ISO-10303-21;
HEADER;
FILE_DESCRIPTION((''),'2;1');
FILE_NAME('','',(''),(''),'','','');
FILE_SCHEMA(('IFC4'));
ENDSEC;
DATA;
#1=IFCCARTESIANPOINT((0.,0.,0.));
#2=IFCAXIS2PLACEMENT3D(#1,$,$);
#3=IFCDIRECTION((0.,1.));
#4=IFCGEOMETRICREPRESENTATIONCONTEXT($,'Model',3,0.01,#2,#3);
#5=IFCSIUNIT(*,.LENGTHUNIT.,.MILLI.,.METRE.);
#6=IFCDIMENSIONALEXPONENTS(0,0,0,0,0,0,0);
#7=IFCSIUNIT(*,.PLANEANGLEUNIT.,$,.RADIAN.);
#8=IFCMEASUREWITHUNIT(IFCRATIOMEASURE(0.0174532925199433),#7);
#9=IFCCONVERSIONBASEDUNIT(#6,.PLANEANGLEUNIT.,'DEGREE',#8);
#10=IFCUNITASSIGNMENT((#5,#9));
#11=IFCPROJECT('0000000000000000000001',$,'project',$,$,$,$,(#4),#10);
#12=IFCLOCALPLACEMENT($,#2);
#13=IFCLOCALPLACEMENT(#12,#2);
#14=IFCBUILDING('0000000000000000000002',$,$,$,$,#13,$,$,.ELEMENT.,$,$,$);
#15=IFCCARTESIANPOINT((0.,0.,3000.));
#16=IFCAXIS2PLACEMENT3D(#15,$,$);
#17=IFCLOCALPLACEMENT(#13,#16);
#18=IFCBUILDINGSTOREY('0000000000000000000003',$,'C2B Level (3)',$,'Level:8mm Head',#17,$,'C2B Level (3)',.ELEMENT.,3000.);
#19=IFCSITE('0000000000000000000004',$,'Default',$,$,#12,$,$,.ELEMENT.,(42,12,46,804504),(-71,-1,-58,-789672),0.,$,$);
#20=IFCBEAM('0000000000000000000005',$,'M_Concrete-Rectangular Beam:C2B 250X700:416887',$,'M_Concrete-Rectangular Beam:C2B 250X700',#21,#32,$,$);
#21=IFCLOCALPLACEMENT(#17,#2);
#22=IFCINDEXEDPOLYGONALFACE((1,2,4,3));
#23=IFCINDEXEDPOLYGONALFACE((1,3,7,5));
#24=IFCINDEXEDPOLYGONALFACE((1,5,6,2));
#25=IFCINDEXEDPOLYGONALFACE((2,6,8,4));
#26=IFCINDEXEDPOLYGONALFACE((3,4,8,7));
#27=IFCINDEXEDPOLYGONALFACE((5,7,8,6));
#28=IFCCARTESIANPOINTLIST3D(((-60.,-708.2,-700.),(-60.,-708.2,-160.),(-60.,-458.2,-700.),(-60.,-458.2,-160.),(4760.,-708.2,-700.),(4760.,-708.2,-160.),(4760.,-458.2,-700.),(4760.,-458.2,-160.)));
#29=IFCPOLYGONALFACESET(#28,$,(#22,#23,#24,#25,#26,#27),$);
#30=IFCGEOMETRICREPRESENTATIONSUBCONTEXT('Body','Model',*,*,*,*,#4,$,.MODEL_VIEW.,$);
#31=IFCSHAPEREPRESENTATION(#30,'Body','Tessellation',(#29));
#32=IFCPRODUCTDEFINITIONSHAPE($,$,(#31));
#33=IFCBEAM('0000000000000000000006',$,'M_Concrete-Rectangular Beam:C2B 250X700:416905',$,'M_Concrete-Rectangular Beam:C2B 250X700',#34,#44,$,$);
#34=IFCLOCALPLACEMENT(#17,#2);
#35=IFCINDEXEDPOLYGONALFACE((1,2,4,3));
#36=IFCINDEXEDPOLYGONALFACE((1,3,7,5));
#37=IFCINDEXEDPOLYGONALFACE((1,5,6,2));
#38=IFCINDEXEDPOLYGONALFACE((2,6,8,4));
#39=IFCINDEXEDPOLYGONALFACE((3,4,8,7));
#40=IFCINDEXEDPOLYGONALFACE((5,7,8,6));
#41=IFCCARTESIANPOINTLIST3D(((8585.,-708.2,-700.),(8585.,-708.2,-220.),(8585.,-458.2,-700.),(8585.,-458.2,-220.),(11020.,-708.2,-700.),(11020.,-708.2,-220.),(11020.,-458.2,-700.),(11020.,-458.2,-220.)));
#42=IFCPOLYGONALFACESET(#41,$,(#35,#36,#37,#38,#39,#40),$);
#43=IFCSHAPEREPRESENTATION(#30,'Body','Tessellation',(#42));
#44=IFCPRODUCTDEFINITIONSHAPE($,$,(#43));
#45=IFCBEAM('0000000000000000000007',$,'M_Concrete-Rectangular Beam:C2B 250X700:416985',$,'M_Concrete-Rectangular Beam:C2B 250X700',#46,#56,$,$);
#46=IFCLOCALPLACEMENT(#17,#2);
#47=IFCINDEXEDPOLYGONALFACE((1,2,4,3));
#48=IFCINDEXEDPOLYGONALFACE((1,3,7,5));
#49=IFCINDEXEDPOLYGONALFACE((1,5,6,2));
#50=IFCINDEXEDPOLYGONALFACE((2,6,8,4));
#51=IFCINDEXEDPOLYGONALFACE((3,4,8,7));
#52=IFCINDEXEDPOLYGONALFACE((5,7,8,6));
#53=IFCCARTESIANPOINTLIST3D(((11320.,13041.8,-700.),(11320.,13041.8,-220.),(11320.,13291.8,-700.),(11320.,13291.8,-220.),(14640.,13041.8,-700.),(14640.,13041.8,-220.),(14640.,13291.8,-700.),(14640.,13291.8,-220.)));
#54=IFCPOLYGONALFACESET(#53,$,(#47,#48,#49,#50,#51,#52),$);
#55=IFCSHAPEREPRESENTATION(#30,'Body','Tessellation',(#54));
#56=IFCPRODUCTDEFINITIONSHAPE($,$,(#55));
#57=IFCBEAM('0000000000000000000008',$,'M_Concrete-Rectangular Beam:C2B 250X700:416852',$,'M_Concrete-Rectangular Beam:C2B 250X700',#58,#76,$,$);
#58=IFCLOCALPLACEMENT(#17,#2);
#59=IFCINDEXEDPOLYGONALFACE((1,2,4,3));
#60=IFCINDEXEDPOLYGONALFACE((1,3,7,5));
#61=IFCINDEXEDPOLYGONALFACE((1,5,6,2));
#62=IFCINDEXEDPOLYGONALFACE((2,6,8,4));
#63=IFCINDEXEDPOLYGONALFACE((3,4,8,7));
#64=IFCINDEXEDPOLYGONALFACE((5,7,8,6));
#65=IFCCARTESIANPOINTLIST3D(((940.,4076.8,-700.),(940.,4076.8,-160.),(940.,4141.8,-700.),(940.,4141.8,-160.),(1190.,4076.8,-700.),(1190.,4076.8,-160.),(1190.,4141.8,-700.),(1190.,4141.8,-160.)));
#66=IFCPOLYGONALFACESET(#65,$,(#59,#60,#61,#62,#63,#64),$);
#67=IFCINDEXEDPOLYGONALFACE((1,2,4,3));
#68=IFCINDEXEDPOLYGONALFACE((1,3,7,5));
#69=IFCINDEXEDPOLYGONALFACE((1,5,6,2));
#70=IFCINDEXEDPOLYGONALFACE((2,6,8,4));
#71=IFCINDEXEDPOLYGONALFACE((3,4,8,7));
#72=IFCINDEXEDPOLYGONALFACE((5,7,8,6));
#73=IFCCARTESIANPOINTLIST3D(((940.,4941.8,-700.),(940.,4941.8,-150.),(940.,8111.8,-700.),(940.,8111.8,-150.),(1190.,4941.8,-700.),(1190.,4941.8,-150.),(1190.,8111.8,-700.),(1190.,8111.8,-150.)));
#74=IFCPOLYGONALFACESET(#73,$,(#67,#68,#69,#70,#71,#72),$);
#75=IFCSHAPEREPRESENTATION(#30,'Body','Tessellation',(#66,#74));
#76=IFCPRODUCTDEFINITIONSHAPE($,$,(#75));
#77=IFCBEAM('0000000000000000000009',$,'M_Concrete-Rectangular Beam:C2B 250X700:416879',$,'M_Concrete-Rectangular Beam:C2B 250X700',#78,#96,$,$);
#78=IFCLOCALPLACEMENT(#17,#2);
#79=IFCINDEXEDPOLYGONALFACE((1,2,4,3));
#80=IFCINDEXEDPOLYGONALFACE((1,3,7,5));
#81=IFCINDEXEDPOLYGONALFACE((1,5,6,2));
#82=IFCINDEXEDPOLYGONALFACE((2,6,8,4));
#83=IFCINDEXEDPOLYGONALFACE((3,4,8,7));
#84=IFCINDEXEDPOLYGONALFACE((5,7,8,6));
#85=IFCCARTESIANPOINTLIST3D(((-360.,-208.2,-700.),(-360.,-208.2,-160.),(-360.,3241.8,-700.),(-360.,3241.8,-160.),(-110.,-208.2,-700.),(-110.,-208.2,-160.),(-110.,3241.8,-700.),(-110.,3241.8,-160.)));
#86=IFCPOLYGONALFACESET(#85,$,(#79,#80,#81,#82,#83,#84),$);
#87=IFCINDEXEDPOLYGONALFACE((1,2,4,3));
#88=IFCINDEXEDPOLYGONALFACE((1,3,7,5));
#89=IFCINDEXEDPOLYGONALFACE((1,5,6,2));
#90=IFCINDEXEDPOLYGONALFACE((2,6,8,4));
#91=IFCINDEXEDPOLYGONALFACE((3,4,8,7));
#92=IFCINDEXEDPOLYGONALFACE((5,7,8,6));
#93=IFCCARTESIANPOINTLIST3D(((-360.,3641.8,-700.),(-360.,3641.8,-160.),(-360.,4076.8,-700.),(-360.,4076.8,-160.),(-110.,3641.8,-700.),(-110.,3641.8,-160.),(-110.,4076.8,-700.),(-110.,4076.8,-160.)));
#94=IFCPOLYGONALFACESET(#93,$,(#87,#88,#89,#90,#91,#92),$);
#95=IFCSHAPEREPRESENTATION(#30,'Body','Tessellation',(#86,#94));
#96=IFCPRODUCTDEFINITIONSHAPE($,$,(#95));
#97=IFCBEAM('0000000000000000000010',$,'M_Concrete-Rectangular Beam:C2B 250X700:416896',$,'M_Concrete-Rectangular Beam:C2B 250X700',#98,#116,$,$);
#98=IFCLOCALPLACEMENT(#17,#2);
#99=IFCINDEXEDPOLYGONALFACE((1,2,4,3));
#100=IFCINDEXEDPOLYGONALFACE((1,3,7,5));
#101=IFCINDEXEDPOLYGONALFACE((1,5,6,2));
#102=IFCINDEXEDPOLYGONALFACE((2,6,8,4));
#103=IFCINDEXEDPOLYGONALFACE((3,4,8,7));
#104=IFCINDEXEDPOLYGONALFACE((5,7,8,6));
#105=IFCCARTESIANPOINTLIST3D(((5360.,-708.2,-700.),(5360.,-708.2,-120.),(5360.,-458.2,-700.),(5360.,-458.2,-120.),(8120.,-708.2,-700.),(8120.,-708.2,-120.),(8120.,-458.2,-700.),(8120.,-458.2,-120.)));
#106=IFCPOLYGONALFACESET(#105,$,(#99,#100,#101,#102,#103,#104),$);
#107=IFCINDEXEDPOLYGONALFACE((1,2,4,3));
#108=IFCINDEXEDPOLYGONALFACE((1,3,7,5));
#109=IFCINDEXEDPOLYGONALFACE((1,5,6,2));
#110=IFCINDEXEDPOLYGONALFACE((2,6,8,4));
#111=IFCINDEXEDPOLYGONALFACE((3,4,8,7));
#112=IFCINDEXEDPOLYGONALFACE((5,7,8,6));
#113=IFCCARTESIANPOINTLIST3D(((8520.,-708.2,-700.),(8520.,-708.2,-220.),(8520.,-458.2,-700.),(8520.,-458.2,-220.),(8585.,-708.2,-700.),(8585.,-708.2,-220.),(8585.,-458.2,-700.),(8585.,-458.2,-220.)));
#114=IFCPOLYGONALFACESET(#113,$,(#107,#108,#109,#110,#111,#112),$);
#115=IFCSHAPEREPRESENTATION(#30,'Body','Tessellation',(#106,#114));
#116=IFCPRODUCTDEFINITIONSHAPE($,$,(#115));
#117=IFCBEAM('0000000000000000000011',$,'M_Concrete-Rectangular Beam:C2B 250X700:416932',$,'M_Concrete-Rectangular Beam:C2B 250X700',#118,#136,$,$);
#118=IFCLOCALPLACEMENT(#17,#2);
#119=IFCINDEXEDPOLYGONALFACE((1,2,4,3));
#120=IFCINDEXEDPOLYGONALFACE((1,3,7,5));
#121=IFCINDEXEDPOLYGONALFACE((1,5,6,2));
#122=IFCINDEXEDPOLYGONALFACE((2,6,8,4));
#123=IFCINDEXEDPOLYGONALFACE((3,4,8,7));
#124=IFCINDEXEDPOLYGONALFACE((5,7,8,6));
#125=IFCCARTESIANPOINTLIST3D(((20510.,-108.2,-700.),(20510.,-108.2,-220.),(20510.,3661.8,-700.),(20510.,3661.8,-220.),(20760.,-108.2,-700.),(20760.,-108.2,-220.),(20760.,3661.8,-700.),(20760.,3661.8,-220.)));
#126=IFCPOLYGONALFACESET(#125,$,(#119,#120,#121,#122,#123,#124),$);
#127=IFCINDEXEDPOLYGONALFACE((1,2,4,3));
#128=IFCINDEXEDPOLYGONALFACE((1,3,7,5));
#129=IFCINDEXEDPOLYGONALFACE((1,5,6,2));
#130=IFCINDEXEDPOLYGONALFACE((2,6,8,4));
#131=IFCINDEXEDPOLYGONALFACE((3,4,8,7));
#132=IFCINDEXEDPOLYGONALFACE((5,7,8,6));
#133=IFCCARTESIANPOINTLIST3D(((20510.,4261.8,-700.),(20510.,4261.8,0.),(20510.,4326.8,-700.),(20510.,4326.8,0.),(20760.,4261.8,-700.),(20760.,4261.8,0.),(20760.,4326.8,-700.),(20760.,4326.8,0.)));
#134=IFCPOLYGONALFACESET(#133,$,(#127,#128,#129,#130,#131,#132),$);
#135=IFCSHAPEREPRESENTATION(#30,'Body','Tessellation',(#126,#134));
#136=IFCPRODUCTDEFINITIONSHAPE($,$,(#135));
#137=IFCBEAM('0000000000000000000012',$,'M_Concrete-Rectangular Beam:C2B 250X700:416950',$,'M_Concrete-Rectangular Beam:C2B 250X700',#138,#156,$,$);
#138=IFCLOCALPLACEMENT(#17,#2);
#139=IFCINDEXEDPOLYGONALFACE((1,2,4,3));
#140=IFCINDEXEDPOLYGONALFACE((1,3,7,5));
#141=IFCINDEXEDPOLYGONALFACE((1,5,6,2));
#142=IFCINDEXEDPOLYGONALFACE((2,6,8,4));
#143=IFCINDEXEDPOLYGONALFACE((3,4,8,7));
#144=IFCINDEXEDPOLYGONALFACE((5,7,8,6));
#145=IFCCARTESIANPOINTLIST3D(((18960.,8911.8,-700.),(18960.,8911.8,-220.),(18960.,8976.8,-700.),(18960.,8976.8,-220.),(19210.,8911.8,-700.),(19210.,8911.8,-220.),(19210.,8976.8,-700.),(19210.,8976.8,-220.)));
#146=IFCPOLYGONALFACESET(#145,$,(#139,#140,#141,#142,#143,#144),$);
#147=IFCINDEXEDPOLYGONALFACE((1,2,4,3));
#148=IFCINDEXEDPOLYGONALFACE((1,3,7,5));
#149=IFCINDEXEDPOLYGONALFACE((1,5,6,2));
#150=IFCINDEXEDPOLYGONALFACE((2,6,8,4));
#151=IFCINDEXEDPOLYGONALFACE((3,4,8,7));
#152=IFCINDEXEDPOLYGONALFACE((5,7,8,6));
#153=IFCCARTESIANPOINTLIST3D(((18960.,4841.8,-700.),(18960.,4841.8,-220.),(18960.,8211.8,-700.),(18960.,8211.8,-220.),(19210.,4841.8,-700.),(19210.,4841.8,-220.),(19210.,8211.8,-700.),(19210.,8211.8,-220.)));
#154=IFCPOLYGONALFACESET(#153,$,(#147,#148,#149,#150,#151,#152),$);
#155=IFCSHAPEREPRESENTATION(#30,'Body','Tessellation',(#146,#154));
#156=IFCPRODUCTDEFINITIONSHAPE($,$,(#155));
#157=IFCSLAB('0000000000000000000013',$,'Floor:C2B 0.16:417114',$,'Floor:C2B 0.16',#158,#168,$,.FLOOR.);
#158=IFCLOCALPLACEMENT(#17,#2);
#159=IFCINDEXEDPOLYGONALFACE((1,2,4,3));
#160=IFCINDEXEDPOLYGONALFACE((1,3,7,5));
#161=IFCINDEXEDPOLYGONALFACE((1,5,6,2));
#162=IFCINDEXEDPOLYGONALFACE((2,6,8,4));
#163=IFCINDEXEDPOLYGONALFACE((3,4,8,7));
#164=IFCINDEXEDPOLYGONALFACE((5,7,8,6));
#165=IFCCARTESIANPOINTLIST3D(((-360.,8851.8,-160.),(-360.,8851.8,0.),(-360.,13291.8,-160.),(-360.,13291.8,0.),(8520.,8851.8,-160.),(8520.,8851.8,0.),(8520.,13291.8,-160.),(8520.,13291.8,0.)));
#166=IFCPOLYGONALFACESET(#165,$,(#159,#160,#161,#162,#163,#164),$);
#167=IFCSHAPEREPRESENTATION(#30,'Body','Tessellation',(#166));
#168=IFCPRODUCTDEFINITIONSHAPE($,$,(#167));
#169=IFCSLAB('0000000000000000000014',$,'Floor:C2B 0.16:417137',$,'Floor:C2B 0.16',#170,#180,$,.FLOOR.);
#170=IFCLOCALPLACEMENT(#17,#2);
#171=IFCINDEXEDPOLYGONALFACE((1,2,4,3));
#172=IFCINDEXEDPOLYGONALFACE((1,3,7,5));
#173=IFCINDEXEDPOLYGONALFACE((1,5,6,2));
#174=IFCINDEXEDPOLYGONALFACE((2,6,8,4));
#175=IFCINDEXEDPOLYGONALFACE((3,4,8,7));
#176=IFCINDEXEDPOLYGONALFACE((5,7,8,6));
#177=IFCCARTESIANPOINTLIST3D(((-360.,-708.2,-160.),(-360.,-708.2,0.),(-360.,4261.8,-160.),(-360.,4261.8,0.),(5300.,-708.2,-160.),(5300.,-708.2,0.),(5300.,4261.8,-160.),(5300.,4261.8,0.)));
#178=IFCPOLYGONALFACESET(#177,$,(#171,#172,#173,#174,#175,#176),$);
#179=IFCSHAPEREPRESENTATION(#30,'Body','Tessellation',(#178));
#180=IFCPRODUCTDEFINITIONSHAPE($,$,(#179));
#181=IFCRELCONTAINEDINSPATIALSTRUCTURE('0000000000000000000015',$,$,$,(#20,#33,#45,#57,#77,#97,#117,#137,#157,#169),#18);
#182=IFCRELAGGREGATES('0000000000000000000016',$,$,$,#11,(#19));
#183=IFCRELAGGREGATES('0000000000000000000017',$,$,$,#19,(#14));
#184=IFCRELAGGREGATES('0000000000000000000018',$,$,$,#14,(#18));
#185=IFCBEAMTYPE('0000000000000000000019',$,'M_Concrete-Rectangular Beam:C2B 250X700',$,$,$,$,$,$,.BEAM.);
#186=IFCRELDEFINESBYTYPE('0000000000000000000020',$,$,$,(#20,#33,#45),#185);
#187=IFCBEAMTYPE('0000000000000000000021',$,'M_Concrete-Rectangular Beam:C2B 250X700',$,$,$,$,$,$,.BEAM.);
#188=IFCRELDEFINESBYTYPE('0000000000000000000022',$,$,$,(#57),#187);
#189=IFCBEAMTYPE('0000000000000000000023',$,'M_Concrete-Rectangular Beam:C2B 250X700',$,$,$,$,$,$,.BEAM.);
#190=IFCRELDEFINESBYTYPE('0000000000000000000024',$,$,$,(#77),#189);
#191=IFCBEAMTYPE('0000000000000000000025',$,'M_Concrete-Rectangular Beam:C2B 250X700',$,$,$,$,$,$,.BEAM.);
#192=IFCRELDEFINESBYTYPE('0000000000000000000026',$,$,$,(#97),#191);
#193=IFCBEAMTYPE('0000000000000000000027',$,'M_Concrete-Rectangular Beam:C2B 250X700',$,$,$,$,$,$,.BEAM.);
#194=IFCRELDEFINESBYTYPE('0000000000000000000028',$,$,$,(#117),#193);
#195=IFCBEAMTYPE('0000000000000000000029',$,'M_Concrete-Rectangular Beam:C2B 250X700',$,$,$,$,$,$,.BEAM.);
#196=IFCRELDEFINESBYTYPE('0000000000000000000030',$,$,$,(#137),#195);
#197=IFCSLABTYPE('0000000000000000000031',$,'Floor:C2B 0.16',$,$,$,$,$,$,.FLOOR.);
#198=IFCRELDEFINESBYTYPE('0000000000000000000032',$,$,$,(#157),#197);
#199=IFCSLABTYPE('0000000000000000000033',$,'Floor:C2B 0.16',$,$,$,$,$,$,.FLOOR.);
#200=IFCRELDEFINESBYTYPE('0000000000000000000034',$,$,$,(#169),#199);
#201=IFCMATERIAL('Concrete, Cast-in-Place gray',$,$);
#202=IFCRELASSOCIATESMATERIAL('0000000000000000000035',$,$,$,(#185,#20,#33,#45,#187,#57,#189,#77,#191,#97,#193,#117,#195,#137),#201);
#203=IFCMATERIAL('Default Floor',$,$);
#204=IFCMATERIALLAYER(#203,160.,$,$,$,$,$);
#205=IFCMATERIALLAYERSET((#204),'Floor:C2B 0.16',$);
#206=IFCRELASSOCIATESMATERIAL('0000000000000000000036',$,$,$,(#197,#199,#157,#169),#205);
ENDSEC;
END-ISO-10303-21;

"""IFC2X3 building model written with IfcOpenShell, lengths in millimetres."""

from ifc_helpers import new_model, entity, si_unit, converted_unit, direction, frame, frame_2d, origin, place, context, subcontext, project, spatial, rectangle, extrude, source, transform, mapped, material, layer, layer_set, layer_usage, type_object, type_shapes, element, save


model = new_model("IFC2X3")

# Units and contexts
model_context = context("Model", 3, precision=0.01, world=origin(), true_north=direction((0.0, 1.0)))
body_context = subcontext(model_context, "Body", "Model", "MODEL_VIEW")
ifc_project = project(units=[si_unit("LENGTHUNIT", "METRE", prefix="MILLI"), converted_unit("PLANEANGLEUNIT", "DEGREE", entity("IfcRatioMeasure", 0.0174532925199433), si_unit("PLANEANGLEUNIT", "RADIAN"), dimensions=[0, 0, 0, 0, 0, 0, 0])], contexts=[model_context])

# Site, building, storey
site_placement = place(None, origin())
site = spatial("IfcSite", under=ifc_project, at=site_placement, Name="Default", CompositionType="ELEMENT", RefLatitude=(42, 12, 46, 804504), RefLongitude=(-71, -1, -58, -789672), RefElevation=0.0)
building_placement = place(site_placement, origin())
building = spatial("IfcBuilding", under=site, at=building_placement, CompositionType="ELEMENT")
storey_placement = place(building_placement, frame((0.0, 0.0, 3000.0)))
storey = spatial("IfcBuildingStorey", under=building, at=storey_placement, Name="C2B Level (3)", ObjectType="Level:8mm Head", LongName="C2B Level (3)", CompositionType="ELEMENT", Elevation=3000.0)

# Beams
ifc_material_1 = material(Name="Concrete, Cast-in-Place gray")
beam_type_1 = type_object("IfcBeamType", Name="M_Concrete-Rectangular Beam:C2B 250X700", PredefinedType="BEAM", material=ifc_material_1)
beam_1_placement = place(storey_placement, frame((4760.0, -583.2, 0.0), z_axis=(0.0, 0.0, 1.0), x_axis=(-1.0, 0.0, 0.0)))
element("IfcBeam", 1, at=beam_1_placement, inside=storey, type_object=beam_type_1, material=ifc_material_1, Name="M_Concrete-Rectangular Beam:C2B 250X700:416887", ObjectType="M_Concrete-Rectangular Beam:C2B 250X700", context=body_context, shape_type="SweptSolid", body=[
    extrude(rectangle(XDim=540.0, YDim=250.0, at=frame_2d((0.0, 0.0), x_axis=(1.0, 0.0))), frame((0.0, 0.0, -430.0), z_axis=(1.0, 0.0, 0.0), x_axis=(0.0, 0.0, -1.0)), (0.0, 0.0, 1.0), 4820.0),
])
beam_2_placement = place(storey_placement, frame((8460.0, -583.2, 0.0)))
element("IfcBeam", 2, at=beam_2_placement, inside=storey, type_object=beam_type_1, material=ifc_material_1, Name="M_Concrete-Rectangular Beam:C2B 250X700:416905", ObjectType="M_Concrete-Rectangular Beam:C2B 250X700", context=body_context, shape_type="SweptSolid", body=[
    extrude(rectangle(XDim=480.0, YDim=250.0, at=frame_2d((0.0, 0.0), x_axis=(1.0, 0.0))), frame((125.0, 0.0, -460.0), z_axis=(1.0, 0.0, 0.0), x_axis=(0.0, 0.0, -1.0)), (0.0, 0.0, 1.0), 2435.0),
])
beam_3_placement = place(storey_placement, frame((14640.0, 13166.8, 0.0), z_axis=(0.0, 0.0, 1.0), x_axis=(-1.0, 0.0, 0.0)))
element("IfcBeam", 3, at=beam_3_placement, inside=storey, type_object=beam_type_1, material=ifc_material_1, Name="M_Concrete-Rectangular Beam:C2B 250X700:416985", ObjectType="M_Concrete-Rectangular Beam:C2B 250X700", context=body_context, shape_type="SweptSolid", body=[
    extrude(rectangle(XDim=480.0, YDim=250.0, at=frame_2d((0.0, 0.0), x_axis=(1.0, 0.0))), frame((0.0, 0.0, -460.0), z_axis=(1.0, 0.0, 0.0), x_axis=(0.0, 0.0, -1.0)), (0.0, 0.0, 1.0), 3320.0),
])
beam_type_2 = type_object("IfcBeamType", Name="M_Concrete-Rectangular Beam:C2B 250X700", PredefinedType="BEAM", material=ifc_material_1)
shared_shape_1 = source(origin(), body_context, "Body", "SweptSolid", [
    extrude(rectangle(XDim=540.0, YDim=250.0, at=frame_2d((0.0, 0.0), x_axis=(0.0, 1.0))), frame((1065.0, 4141.8, 2570.0), z_axis=(0.0, -1.0, 0.0), x_axis=(-1.0, 0.0, 0.0)), (0.0, 0.0, 1.0), 65.0),
    extrude(rectangle(XDim=550.0, YDim=250.0, at=frame_2d((0.0, 0.0), x_axis=(0.0, 1.0))), frame((1065.0, 8111.8, 2575.0), z_axis=(0.0, -1.0, 0.0), x_axis=(-1.0, 0.0, 0.0)), (0.0, 0.0, 1.0), 3170.0),
])
type_shapes(beam_type_2, [shared_shape_1])
beam_4_placement = place(storey_placement, frame((0.0, 0.0, -3000.0)))
element("IfcBeam", 4, at=beam_4_placement, inside=storey, type_object=beam_type_2, material=ifc_material_1, Name="M_Concrete-Rectangular Beam:C2B 250X700:416852", ObjectType="M_Concrete-Rectangular Beam:C2B 250X700", context=body_context, shape_type="MappedRepresentation", body=[
    mapped(shared_shape_1, transform((0.0, 0.0, 0.0), scale=1.0)),
])
beam_type_3 = type_object("IfcBeamType", Name="M_Concrete-Rectangular Beam:C2B 250X700", PredefinedType="BEAM", material=ifc_material_1)
shared_shape_2 = source(origin(), body_context, "Body", "SweptSolid", [
    extrude(rectangle(XDim=540.0, YDim=250.0, at=frame_2d((0.0, 0.0), x_axis=(0.0, 1.0))), frame((-235.0, 3241.8, 2570.0), z_axis=(0.0, -1.0, 0.0), x_axis=(-1.0, 0.0, 0.0)), (0.0, 0.0, 1.0), 3450.0),
    extrude(rectangle(XDim=540.0, YDim=250.0, at=frame_2d((0.0, 0.0), x_axis=(0.0, 1.0))), frame((-235.0, 4076.8, 2570.0), z_axis=(0.0, -1.0, 0.0), x_axis=(-1.0, 0.0, 0.0)), (0.0, 0.0, 1.0), 435.0),
])
type_shapes(beam_type_3, [shared_shape_2])
beam_5_placement = place(storey_placement, frame((0.0, 0.0, -3000.0)))
element("IfcBeam", 5, at=beam_5_placement, inside=storey, type_object=beam_type_3, material=ifc_material_1, Name="M_Concrete-Rectangular Beam:C2B 250X700:416879", ObjectType="M_Concrete-Rectangular Beam:C2B 250X700", context=body_context, shape_type="MappedRepresentation", body=[
    mapped(shared_shape_2, transform((0.0, 0.0, 0.0), scale=1.0)),
])
beam_type_4 = type_object("IfcBeamType", Name="M_Concrete-Rectangular Beam:C2B 250X700", PredefinedType="BEAM", material=ifc_material_1)
shared_shape_3 = source(origin(), body_context, "Body", "SweptSolid", [
    extrude(rectangle(XDim=580.0, YDim=250.0, at=frame_2d((0.0, 0.0), x_axis=(1.0, 0.0))), frame((8120.0, -583.2, 2590.0), z_axis=(-1.0, 0.0, 0.0), x_axis=(0.0, 0.0, -1.0)), (0.0, 0.0, 1.0), 2760.0),
    extrude(rectangle(XDim=480.0, YDim=250.0, at=frame_2d((0.0, 0.0), x_axis=(1.0, 0.0))), frame((8585.0, -583.2, 2540.0), z_axis=(-1.0, 0.0, 0.0), x_axis=(0.0, 0.0, -1.0)), (0.0, 0.0, 1.0), 65.0),
])
type_shapes(beam_type_4, [shared_shape_3])
beam_6_placement = place(storey_placement, frame((0.0, 0.0, -3000.0)))
element("IfcBeam", 6, at=beam_6_placement, inside=storey, type_object=beam_type_4, material=ifc_material_1, Name="M_Concrete-Rectangular Beam:C2B 250X700:416896", ObjectType="M_Concrete-Rectangular Beam:C2B 250X700", context=body_context, shape_type="MappedRepresentation", body=[
    mapped(shared_shape_3, transform((0.0, 0.0, 0.0), scale=1.0)),
])
beam_type_5 = type_object("IfcBeamType", Name="M_Concrete-Rectangular Beam:C2B 250X700", PredefinedType="BEAM", material=ifc_material_1)
shared_shape_4 = source(origin(), body_context, "Body", "SweptSolid", [
    extrude(rectangle(XDim=480.0, YDim=250.0, at=frame_2d((0.0, 0.0), x_axis=(0.0, 1.0))), frame((20635.0, 3661.8, 2540.0), z_axis=(0.0, -1.0, 0.0), x_axis=(-1.0, 0.0, 0.0)), (0.0, 0.0, 1.0), 3770.0),
    extrude(rectangle(XDim=700.0, YDim=250.0, at=frame_2d((0.0, 0.0), x_axis=(0.0, 1.0))), frame((20635.0, 4326.8, 2650.0), z_axis=(0.0, -1.0, 0.0), x_axis=(-1.0, 0.0, 0.0)), (0.0, 0.0, 1.0), 65.0),
])
type_shapes(beam_type_5, [shared_shape_4])
beam_7_placement = place(storey_placement, frame((0.0, 0.0, -3000.0)))
element("IfcBeam", 7, at=beam_7_placement, inside=storey, type_object=beam_type_5, material=ifc_material_1, Name="M_Concrete-Rectangular Beam:C2B 250X700:416932", ObjectType="M_Concrete-Rectangular Beam:C2B 250X700", context=body_context, shape_type="MappedRepresentation", body=[
    mapped(shared_shape_4, transform((0.0, 0.0, 0.0), scale=1.0)),
])
beam_type_6 = type_object("IfcBeamType", Name="M_Concrete-Rectangular Beam:C2B 250X700", PredefinedType="BEAM", material=ifc_material_1)
shared_shape_5 = source(origin(), body_context, "Body", "SweptSolid", [
    extrude(rectangle(XDim=480.0, YDim=250.0, at=frame_2d((0.0, 0.0), x_axis=(0.0, 1.0))), frame((19085.0, 8911.8, 2540.0), z_axis=(0.0, 1.0, 0.0), x_axis=(-1.0, 0.0, 0.0)), (0.0, 0.0, 1.0), 65.0),
    extrude(rectangle(XDim=480.0, YDim=250.0, at=frame_2d((0.0, 0.0), x_axis=(0.0, 1.0))), frame((19085.0, 4841.8, 2540.0), z_axis=(0.0, 1.0, 0.0), x_axis=(-1.0, 0.0, 0.0)), (0.0, 0.0, 1.0), 3370.0),
])
type_shapes(beam_type_6, [shared_shape_5])
beam_8_placement = place(storey_placement, frame((0.0, 0.0, -3000.0)))
element("IfcBeam", 8, at=beam_8_placement, inside=storey, type_object=beam_type_6, material=ifc_material_1, Name="M_Concrete-Rectangular Beam:C2B 250X700:416950", ObjectType="M_Concrete-Rectangular Beam:C2B 250X700", context=body_context, shape_type="MappedRepresentation", body=[
    mapped(shared_shape_5, transform((0.0, 0.0, 0.0), scale=1.0)),
])

# Slabs
ifc_material_2 = material(Name="Default Floor")
ifc_layer_1 = layer(ifc_material_2, 160.0)
ifc_layer_set_1 = layer_set([ifc_layer_1], Name="Floor:C2B 0.16")
ifc_layer_usage_1 = layer_usage(ifc_layer_set_1, "AXIS3", "POSITIVE", 0.0)
slab_type_1 = type_object("IfcSlabType", Name="Floor:C2B 0.16", PredefinedType="FLOOR", material=ifc_layer_set_1)
slab_1_placement = place(storey_placement, origin())
element("IfcSlab", 9, at=slab_1_placement, inside=storey, type_object=slab_type_1, material=ifc_layer_usage_1, Name="Floor:C2B 0.16:417114", ObjectType="Floor:C2B 0.16", PredefinedType="FLOOR", context=body_context, shape_type="SweptSolid", body=[
    extrude(rectangle(XDim=4440.0, YDim=8880.0, at=frame_2d((0.0, 0.0), x_axis=(1.0, 0.0))), frame((4080.0, 11071.8, 0.0), z_axis=(0.0, 0.0, -1.0), x_axis=(0.0, 1.0, 0.0)), (0.0, 0.0, 1.0), 160.0),
])
ifc_layer_usage_2 = layer_usage(ifc_layer_set_1, "AXIS3", "POSITIVE", 0.0)
slab_type_2 = type_object("IfcSlabType", Name="Floor:C2B 0.16", PredefinedType="FLOOR", material=ifc_layer_set_1)
slab_2_placement = place(storey_placement, origin())
element("IfcSlab", 10, at=slab_2_placement, inside=storey, type_object=slab_type_2, material=ifc_layer_usage_2, Name="Floor:C2B 0.16:417137", ObjectType="Floor:C2B 0.16", PredefinedType="FLOOR", context=body_context, shape_type="SweptSolid", body=[
    extrude(rectangle(XDim=4970.0, YDim=5660.0, at=frame_2d((0.0, 0.0), x_axis=(1.0, 0.0))), frame((2470.0, 1776.8, 0.0), z_axis=(0.0, 0.0, -1.0), x_axis=(0.0, 1.0, 0.0)), (0.0, 0.0, 1.0), 160.0),
])

save(model, "model.ifc")
